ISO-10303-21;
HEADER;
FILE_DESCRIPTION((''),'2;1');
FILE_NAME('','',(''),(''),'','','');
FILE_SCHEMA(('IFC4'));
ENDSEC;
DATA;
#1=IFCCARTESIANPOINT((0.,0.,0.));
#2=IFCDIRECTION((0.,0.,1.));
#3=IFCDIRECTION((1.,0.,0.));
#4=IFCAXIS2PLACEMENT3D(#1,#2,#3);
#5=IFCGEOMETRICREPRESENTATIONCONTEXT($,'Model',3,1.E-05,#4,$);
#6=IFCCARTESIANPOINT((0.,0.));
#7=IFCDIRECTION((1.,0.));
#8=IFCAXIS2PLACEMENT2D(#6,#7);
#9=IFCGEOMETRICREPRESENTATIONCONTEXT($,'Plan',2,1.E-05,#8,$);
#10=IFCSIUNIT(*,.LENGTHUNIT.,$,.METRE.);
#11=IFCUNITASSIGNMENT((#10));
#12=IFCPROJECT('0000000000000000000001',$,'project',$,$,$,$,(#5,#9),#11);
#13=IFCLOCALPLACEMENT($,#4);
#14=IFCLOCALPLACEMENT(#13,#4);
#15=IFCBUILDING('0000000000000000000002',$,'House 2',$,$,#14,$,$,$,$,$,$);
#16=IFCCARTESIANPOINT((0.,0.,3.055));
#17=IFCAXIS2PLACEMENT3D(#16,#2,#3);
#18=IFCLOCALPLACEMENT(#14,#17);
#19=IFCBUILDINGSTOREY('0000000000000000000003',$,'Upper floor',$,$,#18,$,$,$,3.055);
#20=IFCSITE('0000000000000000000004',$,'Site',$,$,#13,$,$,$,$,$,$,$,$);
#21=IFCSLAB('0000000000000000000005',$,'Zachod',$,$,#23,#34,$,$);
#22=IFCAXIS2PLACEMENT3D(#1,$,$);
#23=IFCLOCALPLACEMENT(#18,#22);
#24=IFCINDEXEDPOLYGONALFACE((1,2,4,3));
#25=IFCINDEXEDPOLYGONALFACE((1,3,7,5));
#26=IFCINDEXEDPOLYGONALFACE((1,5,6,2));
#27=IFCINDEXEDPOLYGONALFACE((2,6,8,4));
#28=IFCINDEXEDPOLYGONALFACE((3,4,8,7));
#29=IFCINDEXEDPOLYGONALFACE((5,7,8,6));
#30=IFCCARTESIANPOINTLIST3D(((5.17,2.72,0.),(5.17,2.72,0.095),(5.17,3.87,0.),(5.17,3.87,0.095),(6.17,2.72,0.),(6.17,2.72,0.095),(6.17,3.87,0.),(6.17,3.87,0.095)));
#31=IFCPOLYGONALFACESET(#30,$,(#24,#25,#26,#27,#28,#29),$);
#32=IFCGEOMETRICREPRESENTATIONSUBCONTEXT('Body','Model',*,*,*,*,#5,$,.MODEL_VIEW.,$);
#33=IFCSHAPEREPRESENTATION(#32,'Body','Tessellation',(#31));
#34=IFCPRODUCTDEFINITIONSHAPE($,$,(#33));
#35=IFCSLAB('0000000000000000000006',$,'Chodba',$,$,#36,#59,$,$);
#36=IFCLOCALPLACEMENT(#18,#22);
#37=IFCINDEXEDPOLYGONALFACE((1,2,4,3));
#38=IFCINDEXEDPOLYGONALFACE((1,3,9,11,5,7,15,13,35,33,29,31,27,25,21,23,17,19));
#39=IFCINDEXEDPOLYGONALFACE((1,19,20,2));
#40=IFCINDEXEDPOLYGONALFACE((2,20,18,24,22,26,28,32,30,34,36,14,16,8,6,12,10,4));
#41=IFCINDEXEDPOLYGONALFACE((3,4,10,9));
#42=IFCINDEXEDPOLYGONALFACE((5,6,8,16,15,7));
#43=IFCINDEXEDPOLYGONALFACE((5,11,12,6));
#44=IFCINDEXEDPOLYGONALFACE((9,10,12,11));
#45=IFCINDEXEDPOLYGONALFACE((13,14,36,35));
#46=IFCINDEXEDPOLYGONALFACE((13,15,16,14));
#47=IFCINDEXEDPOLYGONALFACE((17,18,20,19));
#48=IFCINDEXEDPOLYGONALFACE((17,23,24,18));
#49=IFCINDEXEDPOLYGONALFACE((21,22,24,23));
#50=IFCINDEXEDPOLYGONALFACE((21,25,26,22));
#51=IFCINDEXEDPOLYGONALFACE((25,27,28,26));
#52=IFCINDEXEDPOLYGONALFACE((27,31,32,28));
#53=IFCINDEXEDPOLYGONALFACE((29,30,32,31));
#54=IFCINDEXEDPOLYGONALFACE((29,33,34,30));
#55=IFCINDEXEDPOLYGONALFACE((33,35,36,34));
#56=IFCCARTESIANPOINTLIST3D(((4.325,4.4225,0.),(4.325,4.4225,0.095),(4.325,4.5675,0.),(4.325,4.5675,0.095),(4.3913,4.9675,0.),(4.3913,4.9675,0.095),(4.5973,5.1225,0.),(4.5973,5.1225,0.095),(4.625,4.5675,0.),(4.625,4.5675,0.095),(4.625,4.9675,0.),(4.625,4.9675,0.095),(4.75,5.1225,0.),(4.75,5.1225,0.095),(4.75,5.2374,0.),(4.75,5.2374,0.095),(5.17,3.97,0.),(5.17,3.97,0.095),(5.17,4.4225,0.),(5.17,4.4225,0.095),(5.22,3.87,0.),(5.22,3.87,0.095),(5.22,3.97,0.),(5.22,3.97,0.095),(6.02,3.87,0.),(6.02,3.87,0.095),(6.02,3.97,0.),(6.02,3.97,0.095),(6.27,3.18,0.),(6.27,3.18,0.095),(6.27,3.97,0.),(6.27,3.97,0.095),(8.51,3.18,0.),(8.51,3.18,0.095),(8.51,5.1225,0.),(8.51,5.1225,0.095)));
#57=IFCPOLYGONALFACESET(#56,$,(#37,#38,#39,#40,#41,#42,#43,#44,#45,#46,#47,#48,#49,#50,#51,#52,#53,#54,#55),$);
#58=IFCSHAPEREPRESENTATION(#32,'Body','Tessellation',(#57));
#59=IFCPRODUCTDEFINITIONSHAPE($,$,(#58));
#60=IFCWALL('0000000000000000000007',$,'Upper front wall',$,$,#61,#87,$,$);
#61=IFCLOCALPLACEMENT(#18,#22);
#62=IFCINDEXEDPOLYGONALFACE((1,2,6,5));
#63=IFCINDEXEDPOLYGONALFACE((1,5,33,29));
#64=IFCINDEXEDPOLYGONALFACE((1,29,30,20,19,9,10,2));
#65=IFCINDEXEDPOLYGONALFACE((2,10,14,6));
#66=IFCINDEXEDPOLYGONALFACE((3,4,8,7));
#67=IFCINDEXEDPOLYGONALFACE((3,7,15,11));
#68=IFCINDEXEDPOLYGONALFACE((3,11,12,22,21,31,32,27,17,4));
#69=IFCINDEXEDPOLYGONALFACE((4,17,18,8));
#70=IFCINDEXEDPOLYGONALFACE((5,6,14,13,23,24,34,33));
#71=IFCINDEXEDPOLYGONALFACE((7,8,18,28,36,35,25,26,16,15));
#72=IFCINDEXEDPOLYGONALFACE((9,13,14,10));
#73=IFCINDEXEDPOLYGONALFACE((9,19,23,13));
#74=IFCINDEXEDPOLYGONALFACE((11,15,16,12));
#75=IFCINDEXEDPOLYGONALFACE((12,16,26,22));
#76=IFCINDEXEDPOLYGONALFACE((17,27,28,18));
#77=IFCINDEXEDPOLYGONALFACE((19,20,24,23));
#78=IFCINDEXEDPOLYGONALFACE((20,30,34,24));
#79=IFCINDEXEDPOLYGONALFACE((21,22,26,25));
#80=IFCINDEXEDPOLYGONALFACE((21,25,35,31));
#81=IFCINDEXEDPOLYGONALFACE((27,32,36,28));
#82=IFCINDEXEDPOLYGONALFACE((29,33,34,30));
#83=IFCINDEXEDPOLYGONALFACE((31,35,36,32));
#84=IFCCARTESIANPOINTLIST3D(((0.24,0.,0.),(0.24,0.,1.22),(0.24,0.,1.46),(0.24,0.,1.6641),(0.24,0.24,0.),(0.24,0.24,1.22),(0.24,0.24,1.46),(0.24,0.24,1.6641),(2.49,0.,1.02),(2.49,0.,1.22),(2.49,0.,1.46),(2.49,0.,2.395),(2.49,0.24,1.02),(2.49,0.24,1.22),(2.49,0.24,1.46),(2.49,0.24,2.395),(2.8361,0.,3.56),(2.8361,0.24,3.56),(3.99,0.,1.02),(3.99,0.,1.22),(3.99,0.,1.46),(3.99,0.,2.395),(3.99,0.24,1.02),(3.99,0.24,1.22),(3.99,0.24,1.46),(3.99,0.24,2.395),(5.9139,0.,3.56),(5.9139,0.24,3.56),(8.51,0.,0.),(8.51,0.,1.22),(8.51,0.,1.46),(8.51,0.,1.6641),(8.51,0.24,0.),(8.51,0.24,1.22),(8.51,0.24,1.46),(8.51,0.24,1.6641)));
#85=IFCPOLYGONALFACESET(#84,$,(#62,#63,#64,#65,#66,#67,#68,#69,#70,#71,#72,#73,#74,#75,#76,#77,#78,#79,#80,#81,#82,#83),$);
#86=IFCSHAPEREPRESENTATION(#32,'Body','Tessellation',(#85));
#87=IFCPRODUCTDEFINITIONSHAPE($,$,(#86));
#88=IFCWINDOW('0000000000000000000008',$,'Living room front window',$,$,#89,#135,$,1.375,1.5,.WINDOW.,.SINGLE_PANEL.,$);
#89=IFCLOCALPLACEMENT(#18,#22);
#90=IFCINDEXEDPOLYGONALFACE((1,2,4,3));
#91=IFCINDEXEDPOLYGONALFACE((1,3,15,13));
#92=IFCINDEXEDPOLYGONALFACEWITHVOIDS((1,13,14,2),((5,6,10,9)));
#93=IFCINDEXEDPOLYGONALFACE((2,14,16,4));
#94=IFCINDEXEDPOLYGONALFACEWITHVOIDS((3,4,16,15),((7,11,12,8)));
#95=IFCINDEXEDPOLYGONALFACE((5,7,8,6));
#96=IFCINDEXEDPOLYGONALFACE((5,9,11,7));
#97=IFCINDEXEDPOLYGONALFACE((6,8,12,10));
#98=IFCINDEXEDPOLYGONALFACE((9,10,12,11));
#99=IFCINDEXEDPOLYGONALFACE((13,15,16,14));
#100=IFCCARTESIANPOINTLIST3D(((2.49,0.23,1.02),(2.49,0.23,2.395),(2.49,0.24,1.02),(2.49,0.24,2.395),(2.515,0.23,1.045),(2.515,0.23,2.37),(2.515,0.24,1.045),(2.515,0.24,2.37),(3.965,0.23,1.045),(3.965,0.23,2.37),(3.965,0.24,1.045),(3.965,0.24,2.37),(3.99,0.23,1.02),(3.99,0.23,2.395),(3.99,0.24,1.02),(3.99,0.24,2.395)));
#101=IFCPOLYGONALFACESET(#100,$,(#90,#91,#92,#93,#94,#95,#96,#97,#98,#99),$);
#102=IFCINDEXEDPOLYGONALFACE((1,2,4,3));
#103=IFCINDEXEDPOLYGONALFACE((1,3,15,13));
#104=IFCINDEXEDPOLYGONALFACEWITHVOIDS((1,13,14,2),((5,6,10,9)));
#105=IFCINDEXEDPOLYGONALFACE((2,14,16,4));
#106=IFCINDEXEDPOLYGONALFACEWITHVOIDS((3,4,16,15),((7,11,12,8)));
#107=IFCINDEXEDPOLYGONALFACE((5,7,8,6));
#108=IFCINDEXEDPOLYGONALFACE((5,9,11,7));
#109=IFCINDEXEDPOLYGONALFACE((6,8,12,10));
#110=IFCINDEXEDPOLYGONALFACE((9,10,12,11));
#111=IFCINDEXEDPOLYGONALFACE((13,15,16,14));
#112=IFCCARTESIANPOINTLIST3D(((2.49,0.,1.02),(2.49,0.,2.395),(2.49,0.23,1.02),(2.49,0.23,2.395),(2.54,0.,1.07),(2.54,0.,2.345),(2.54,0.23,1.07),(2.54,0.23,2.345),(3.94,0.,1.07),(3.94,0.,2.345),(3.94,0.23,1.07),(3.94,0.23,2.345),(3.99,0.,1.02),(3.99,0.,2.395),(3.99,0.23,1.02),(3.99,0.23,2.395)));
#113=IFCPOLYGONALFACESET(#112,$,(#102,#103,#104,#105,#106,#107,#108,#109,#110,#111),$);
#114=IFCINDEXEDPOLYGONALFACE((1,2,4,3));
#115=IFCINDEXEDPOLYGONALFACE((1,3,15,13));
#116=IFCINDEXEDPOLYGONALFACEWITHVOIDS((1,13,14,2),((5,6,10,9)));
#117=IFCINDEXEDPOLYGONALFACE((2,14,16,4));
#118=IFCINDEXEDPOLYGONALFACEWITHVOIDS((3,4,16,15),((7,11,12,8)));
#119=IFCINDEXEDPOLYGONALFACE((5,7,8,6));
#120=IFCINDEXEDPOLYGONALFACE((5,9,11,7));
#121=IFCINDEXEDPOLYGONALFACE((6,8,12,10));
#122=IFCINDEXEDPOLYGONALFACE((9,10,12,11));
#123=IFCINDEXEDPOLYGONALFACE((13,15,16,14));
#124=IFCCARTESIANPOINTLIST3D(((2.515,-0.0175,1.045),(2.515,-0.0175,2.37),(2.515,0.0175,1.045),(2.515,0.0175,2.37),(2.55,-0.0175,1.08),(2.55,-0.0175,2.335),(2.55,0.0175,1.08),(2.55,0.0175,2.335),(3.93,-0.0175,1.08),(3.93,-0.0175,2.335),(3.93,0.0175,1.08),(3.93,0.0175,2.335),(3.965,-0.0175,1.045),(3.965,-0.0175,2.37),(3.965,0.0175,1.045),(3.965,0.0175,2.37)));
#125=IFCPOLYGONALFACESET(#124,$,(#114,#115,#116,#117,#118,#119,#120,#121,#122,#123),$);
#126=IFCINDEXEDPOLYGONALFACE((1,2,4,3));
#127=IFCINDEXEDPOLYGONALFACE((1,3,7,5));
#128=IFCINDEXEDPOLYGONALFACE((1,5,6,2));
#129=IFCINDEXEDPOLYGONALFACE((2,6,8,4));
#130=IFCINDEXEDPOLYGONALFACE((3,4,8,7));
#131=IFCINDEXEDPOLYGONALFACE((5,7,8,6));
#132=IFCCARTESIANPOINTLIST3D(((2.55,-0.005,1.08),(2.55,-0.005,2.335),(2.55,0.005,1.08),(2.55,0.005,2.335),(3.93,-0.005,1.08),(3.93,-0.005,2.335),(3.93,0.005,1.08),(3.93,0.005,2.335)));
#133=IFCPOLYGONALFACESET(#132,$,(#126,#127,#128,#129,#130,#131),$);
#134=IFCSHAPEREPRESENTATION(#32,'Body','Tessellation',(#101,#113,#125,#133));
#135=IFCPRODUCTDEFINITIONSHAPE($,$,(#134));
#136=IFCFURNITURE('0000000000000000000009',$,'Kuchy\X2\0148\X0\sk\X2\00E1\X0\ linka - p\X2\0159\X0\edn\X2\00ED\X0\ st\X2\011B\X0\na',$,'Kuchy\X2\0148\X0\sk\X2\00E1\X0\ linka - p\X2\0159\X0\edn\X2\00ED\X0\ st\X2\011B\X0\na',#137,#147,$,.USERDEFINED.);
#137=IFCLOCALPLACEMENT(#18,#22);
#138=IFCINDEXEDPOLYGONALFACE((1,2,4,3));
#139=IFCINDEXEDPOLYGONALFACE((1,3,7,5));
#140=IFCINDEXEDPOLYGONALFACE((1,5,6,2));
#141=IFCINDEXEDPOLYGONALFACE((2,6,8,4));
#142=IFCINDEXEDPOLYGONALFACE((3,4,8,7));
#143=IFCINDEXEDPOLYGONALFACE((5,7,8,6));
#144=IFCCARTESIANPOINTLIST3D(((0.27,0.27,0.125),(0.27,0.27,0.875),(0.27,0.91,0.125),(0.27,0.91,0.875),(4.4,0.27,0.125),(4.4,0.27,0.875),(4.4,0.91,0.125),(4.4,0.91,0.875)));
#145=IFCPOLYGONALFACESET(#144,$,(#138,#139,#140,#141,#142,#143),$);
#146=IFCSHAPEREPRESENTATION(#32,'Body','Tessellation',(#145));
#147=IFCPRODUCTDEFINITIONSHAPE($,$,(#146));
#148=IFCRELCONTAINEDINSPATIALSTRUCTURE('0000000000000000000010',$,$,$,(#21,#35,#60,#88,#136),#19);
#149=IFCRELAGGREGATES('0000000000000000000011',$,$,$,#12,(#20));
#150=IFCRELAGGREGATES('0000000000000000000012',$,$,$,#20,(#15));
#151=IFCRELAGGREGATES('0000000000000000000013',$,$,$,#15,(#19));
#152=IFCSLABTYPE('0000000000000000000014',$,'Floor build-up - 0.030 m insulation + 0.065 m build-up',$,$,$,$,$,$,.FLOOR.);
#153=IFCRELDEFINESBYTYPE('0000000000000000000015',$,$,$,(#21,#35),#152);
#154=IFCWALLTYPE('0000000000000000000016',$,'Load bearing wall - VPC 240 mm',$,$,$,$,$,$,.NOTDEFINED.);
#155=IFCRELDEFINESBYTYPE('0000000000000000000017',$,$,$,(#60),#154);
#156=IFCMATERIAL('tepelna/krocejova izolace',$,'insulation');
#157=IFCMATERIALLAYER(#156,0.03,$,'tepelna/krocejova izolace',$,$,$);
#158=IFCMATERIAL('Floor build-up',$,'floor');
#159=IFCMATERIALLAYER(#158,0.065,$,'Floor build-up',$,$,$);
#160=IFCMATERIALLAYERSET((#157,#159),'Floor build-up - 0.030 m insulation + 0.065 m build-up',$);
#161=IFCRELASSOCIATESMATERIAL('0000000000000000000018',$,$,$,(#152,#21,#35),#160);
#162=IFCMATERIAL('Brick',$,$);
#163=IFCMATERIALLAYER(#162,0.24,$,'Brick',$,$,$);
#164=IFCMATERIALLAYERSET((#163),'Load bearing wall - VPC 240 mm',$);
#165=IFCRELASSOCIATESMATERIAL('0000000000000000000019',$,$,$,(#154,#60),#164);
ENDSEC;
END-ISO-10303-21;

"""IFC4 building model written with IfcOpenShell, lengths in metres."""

from ifc_helpers import new_model, entity, si_unit, frame, origin_with_axes, origin_2d_with_axis, place, context, subcontext, project, spatial, line, indexed_curve, outline, extrude, boolean, clip, halfspace, shape, material, layer, layer_set, layer_usage, type_object, element, fill, save


model = new_model("IFC4")

# Units and contexts
model_context = context("Model", 3, precision=1e-05, world=origin_with_axes())
plan_context = context("Plan", 2, precision=1e-05, world=origin_2d_with_axis())
body_context_1 = subcontext(model_context, "Body", "Model", "MODEL_VIEW")
body_context_2 = subcontext(plan_context, "Body", "Plan", "PLAN_VIEW")
ifc_project = project(units=[si_unit("LENGTHUNIT", "METRE")], contexts=[model_context, plan_context])

# Site, building, storey
site_placement = place(None, origin_with_axes())
site = spatial("IfcSite", under=ifc_project, at=site_placement, Name="Site")
building_placement = place(site_placement, origin_with_axes())
building = spatial("IfcBuilding", under=site, at=building_placement, Name="House 2")
storey_placement = place(building_placement, frame((0.0, 0.0, 3.055), z_axis=(0.0, 0.0, 1.0), x_axis=(1.0, 0.0, 0.0)))
storey = spatial("IfcBuildingStorey", under=building, at=storey_placement, Name="Upper floor", Elevation=3.055)

# Slabs
ifc_material_1 = material(Name="tepelna/krocejova izolace", Category="insulation")
ifc_layer_1 = layer(ifc_material_1, 0.03, Name="tepelna/krocejova izolace")
ifc_material_2 = material(Name="Floor build-up", Category="floor")
ifc_layer_2 = layer(ifc_material_2, 0.065, Name="Floor build-up")
ifc_layer_set_1 = layer_set([ifc_layer_1, ifc_layer_2], Name="Floor build-up - 0.030 m insulation + 0.065 m build-up")
slab_type = type_object("IfcSlabType", Name="Floor build-up - 0.030 m insulation + 0.065 m build-up", PredefinedType="FLOOR", material=ifc_layer_set_1)
ifc_layer_usage_1 = layer_usage(ifc_layer_set_1, "AXIS3", "POSITIVE", 0.0)
slab_1_placement = place(storey_placement, origin_with_axes())
element("IfcSlab", 1, at=slab_1_placement, inside=storey, type_object=slab_type, material=ifc_layer_usage_1, Name="Zachod", context=body_context_1, shape_type="SweptSolid", body=[
    extrude(outline(indexed_curve([(6.17, 2.72), (6.17, 3.87), (5.17, 3.87), (5.17, 2.72)])), None, (0.0, 0.0, 1.0), 0.095),
])
ifc_layer_usage_2 = layer_usage(ifc_layer_set_1, "AXIS3", "POSITIVE", 0.0)
slab_2_placement = place(storey_placement, origin_with_axes())
element("IfcSlab", 2, at=slab_2_placement, inside=storey, type_object=slab_type, material=ifc_layer_usage_2, Name="Chodba", context=body_context_1, shape_type="SweptSolid", body=[
    extrude(outline(indexed_curve([(4.325, 4.5675), (4.625, 4.5675), (4.625, 4.9675), (4.3913, 4.9675), (4.5973, 5.1225), (4.75, 5.2374), (4.75, 5.1225), (8.51, 5.1225), (8.51, 3.18), (6.27, 3.18), (6.27, 3.97), (6.02, 3.97), (6.02, 3.87), (5.22, 3.87), (5.22, 3.97), (5.17, 3.97), (5.17, 4.4225), (4.325, 4.4225)])), None, (0.0, 0.0, 1.0), 0.095),
])

# Wall, opening, window
ifc_material_3 = material(Name="Brick")
ifc_layer_3 = layer(ifc_material_3, 0.24, Name="Brick")
ifc_layer_set_2 = layer_set([ifc_layer_3], Name="Load bearing wall - VPC 240 mm")
ifc_layer_usage_3 = layer_usage(ifc_layer_set_2, "AXIS2", "NEGATIVE", 0.24)
wall_type = type_object("IfcWallType", Name="Load bearing wall - VPC 240 mm", PredefinedType="NOTDEFINED", material=ifc_layer_set_2)
wall_placement = place(storey_placement, frame((0.24, 0.0, 0.0), z_axis=(0.0, 0.0, 1.0), x_axis=(1.0, 0.0, 0.0)))
wall = element("IfcWall", 3, at=wall_placement, inside=storey, type_object=wall_type, material=ifc_layer_usage_3, Name="Upper front wall", context=body_context_1, shape_type="CSG", body=[
    boolean("DIFFERENCE", boolean("DIFFERENCE", clip(clip(clip(extrude(outline(indexed_curve([(0.0, 0.0), (0.0, 0.24), (8.27, 0.24), (8.27, 0.0), (0.0, 0.0)], self_intersect=False)), origin_with_axes(), (0.0, 0.0, 1.0), 3.56), halfspace(frame((-0.1705, 0.0, 1.5396), z_axis=(-0.58975, 0.0, 0.807586), x_axis=(0.0, 1.0, 0.0)), False)), halfspace(frame((8.4405, 0.0, 1.5396), z_axis=(0.58975, 0.0, 0.807586), x_axis=(0.0, -1.0, 0.0)), False)), halfspace(frame((-0.24, 0.0, 3.56), z_axis=(0.0, 0.0, 1.0), x_axis=(-1.0, 0.0, 0.0)), False)), extrude(outline(indexed_curve([(0.0, 0.0), (2.26, 0.0), (2.26, 0.24), (0.0, 0.24)], segments=[line(1, 2, 3, 4, 1)])), frame((-0.01, 0.0, 1.22), z_axis=(0.0, 0.0, 1.0), x_axis=(1.0, 0.0, 0.0)), (0.0, 0.0, 1.0), 0.24)), extrude(outline(indexed_curve([(0.0, 0.0), (4.53, 0.0), (4.53, 0.24), (0.0, 0.24)], segments=[line(1, 2, 3, 4, 1)])), frame((3.75, 0.0, 1.22), z_axis=(0.0, 0.0, 1.0), x_axis=(1.0, 0.0, 0.0)), (0.0, 0.0, 1.0), 0.24)),
])
opening_placement = place(wall_placement, frame((2.25, 0.0, 1.02), z_axis=(0.0, 0.0, 1.0), x_axis=(1.0, 0.0, 0.0)))
opening = element("IfcOpeningElement", 4, at=opening_placement, cuts=wall, PredefinedType="OPENING", context=body_context_1, shape_type="SweptSolid", body=[
    extrude(outline(indexed_curve([(0.0, 0.0), (0.0, 0.34), (1.5, 0.34), (1.5, 0.0), (0.0, 0.0)], self_intersect=False)), frame((0.0, -0.05, 0.0), z_axis=(0.0, 0.0, 1.0), x_axis=(1.0, 0.0, 0.0)), (0.0, 0.0, 1.0), 1.375),
])
window_placement = place(opening_placement, origin_with_axes())
window = element("IfcWindow", 5, at=window_placement, inside=storey, Name="Living room front window", OverallHeight=1.375, OverallWidth=1.5, PartitioningType="SINGLE_PANEL", PredefinedType="WINDOW", shapes=[
    shape(body_context_1, "Body", "SweptSolid", [extrude(outline(indexed_curve([(0.0, 0.0), (1.5, 0.0), (1.5, 1.375), (0.0, 1.375)], segments=[line(1, 2, 3, 4, 1)]), holes=[indexed_curve([(0.025, 0.025), (1.475, 0.025), (1.475, 1.35), (0.025, 1.35)], segments=[line(1, 2, 3, 4, 1)])]), frame((0.0, 0.23, 0.0), z_axis=(0.0, -1.0, 0.0), x_axis=(1.0, 0.0, 0.0)), (0.0, 0.0, -1.0), 0.01), extrude(outline(indexed_curve([(0.0, 0.0), (1.5, 0.0), (1.5, 1.375), (0.0, 1.375)], segments=[line(1, 2, 3, 4, 1)]), holes=[indexed_curve([(0.05, 0.05), (1.45, 0.05), (1.45, 1.325), (0.05, 1.325)], segments=[line(1, 2, 3, 4, 1)])]), frame((0.0, 0.0, 0.0), z_axis=(0.0, -1.0, 0.0), x_axis=(1.0, 0.0, 0.0)), (0.0, 0.0, -1.0), 0.23), extrude(outline(indexed_curve([(0.0, 0.0), (1.45, 0.0), (1.45, 1.325), (0.0, 1.325)], segments=[line(1, 2, 3, 4, 1)]), holes=[indexed_curve([(0.035, 0.035), (1.415, 0.035), (1.415, 1.29), (0.035, 1.29)], segments=[line(1, 2, 3, 4, 1)])]), frame((0.025, -0.0175, 0.025), z_axis=(0.0, -1.0, 0.0), x_axis=(1.0, 0.0, 0.0)), (0.0, 0.0, -1.0), 0.035), extrude(outline(indexed_curve([(0.035, 0.035), (1.415, 0.035), (1.415, 1.29), (0.035, 1.29)], segments=[line(1, 2, 3, 4, 1)])), frame((0.025, -0.005, 0.025), z_axis=(0.0, -1.0, 0.0), x_axis=(1.0, 0.0, 0.0)), (0.0, 0.0, -1.0), 0.01)]),
    shape(body_context_2, "Body", "Curve2D", [entity("IfcIndexedPolyCurve", entity("IfcCartesianPointList2D", [[0.05, 0.0], [1.45, 0.0]])), entity("IfcIndexedPolyCurve", entity("IfcCartesianPointList2D", [[0.0, 0.24], [0.025, 0.24], [0.025, 0.23], [0.05, 0.23], [0.05, 0.0], [0.0, 0.0]]), [entity("IfcLineIndex", [1, 2, 3, 4, 5, 6, 1])]), entity("IfcIndexedPolyCurve", entity("IfcCartesianPointList2D", [[1.5, 0.24], [1.475, 0.24], [1.475, 0.23], [1.45, 0.23], [1.45, 0.0], [1.5, 0.0]]), [entity("IfcLineIndex", [1, 2, 3, 4, 5, 6, 1])]), entity("IfcIndexedPolyCurve", entity("IfcCartesianPointList2D", [[0.025, -0.0175], [0.06, -0.0175], [0.06, 0.0175], [0.025, 0.0175]]), [entity("IfcLineIndex", [1, 2, 3, 4, 1])]), entity("IfcIndexedPolyCurve", entity("IfcCartesianPointList2D", [[1.475, -0.0175], [1.44, -0.0175], [1.44, 0.0175], [1.475, 0.0175]]), [entity("IfcLineIndex", [1, 2, 3, 4, 1])]), entity("IfcIndexedPolyCurve", entity("IfcCartesianPointList2D", [[0.06, -0.0175], [1.44, -0.0175]])), entity("IfcIndexedPolyCurve", entity("IfcCartesianPointList2D", [[0.06, 0.0175], [1.44, 0.0175]])), entity("IfcIndexedPolyCurve", entity("IfcCartesianPointList2D", [[0.06, 0.0], [1.44, 0.0]]))]),
])
fill(opening, window)

# Furniture
furniture_placement = place(storey_placement, frame((2.335, 0.59, 0.125), z_axis=(0.0, 0.0, 1.0), x_axis=(1.0, 0.0, 0.0)))
element("IfcFurniture", 6, at=furniture_placement, inside=storey, Name="Kuchyňská linka - přední stěna", ObjectType="Kuchyňská linka - přední stěna", PredefinedType="USERDEFINED", shapes=[
    shape(body_context_1, "Body", "SweptSolid", [extrude(outline(indexed_curve([(-2.065, -0.32), (2.065, -0.32), (2.065, 0.32), (-2.065, 0.32)])), None, (0.0, 0.0, 1.0), 0.75)]),
    shape(body_context_2, "Body", "Curve2D", [entity("IfcIndexedPolyCurve", entity("IfcCartesianPointList2D", [[-2.065, -0.32], [2.065, -0.32], [2.065, 0.32], [-2.065, 0.32], [-2.065, -0.32]]), None, False)]),
])

save(model, "model.ifc")
